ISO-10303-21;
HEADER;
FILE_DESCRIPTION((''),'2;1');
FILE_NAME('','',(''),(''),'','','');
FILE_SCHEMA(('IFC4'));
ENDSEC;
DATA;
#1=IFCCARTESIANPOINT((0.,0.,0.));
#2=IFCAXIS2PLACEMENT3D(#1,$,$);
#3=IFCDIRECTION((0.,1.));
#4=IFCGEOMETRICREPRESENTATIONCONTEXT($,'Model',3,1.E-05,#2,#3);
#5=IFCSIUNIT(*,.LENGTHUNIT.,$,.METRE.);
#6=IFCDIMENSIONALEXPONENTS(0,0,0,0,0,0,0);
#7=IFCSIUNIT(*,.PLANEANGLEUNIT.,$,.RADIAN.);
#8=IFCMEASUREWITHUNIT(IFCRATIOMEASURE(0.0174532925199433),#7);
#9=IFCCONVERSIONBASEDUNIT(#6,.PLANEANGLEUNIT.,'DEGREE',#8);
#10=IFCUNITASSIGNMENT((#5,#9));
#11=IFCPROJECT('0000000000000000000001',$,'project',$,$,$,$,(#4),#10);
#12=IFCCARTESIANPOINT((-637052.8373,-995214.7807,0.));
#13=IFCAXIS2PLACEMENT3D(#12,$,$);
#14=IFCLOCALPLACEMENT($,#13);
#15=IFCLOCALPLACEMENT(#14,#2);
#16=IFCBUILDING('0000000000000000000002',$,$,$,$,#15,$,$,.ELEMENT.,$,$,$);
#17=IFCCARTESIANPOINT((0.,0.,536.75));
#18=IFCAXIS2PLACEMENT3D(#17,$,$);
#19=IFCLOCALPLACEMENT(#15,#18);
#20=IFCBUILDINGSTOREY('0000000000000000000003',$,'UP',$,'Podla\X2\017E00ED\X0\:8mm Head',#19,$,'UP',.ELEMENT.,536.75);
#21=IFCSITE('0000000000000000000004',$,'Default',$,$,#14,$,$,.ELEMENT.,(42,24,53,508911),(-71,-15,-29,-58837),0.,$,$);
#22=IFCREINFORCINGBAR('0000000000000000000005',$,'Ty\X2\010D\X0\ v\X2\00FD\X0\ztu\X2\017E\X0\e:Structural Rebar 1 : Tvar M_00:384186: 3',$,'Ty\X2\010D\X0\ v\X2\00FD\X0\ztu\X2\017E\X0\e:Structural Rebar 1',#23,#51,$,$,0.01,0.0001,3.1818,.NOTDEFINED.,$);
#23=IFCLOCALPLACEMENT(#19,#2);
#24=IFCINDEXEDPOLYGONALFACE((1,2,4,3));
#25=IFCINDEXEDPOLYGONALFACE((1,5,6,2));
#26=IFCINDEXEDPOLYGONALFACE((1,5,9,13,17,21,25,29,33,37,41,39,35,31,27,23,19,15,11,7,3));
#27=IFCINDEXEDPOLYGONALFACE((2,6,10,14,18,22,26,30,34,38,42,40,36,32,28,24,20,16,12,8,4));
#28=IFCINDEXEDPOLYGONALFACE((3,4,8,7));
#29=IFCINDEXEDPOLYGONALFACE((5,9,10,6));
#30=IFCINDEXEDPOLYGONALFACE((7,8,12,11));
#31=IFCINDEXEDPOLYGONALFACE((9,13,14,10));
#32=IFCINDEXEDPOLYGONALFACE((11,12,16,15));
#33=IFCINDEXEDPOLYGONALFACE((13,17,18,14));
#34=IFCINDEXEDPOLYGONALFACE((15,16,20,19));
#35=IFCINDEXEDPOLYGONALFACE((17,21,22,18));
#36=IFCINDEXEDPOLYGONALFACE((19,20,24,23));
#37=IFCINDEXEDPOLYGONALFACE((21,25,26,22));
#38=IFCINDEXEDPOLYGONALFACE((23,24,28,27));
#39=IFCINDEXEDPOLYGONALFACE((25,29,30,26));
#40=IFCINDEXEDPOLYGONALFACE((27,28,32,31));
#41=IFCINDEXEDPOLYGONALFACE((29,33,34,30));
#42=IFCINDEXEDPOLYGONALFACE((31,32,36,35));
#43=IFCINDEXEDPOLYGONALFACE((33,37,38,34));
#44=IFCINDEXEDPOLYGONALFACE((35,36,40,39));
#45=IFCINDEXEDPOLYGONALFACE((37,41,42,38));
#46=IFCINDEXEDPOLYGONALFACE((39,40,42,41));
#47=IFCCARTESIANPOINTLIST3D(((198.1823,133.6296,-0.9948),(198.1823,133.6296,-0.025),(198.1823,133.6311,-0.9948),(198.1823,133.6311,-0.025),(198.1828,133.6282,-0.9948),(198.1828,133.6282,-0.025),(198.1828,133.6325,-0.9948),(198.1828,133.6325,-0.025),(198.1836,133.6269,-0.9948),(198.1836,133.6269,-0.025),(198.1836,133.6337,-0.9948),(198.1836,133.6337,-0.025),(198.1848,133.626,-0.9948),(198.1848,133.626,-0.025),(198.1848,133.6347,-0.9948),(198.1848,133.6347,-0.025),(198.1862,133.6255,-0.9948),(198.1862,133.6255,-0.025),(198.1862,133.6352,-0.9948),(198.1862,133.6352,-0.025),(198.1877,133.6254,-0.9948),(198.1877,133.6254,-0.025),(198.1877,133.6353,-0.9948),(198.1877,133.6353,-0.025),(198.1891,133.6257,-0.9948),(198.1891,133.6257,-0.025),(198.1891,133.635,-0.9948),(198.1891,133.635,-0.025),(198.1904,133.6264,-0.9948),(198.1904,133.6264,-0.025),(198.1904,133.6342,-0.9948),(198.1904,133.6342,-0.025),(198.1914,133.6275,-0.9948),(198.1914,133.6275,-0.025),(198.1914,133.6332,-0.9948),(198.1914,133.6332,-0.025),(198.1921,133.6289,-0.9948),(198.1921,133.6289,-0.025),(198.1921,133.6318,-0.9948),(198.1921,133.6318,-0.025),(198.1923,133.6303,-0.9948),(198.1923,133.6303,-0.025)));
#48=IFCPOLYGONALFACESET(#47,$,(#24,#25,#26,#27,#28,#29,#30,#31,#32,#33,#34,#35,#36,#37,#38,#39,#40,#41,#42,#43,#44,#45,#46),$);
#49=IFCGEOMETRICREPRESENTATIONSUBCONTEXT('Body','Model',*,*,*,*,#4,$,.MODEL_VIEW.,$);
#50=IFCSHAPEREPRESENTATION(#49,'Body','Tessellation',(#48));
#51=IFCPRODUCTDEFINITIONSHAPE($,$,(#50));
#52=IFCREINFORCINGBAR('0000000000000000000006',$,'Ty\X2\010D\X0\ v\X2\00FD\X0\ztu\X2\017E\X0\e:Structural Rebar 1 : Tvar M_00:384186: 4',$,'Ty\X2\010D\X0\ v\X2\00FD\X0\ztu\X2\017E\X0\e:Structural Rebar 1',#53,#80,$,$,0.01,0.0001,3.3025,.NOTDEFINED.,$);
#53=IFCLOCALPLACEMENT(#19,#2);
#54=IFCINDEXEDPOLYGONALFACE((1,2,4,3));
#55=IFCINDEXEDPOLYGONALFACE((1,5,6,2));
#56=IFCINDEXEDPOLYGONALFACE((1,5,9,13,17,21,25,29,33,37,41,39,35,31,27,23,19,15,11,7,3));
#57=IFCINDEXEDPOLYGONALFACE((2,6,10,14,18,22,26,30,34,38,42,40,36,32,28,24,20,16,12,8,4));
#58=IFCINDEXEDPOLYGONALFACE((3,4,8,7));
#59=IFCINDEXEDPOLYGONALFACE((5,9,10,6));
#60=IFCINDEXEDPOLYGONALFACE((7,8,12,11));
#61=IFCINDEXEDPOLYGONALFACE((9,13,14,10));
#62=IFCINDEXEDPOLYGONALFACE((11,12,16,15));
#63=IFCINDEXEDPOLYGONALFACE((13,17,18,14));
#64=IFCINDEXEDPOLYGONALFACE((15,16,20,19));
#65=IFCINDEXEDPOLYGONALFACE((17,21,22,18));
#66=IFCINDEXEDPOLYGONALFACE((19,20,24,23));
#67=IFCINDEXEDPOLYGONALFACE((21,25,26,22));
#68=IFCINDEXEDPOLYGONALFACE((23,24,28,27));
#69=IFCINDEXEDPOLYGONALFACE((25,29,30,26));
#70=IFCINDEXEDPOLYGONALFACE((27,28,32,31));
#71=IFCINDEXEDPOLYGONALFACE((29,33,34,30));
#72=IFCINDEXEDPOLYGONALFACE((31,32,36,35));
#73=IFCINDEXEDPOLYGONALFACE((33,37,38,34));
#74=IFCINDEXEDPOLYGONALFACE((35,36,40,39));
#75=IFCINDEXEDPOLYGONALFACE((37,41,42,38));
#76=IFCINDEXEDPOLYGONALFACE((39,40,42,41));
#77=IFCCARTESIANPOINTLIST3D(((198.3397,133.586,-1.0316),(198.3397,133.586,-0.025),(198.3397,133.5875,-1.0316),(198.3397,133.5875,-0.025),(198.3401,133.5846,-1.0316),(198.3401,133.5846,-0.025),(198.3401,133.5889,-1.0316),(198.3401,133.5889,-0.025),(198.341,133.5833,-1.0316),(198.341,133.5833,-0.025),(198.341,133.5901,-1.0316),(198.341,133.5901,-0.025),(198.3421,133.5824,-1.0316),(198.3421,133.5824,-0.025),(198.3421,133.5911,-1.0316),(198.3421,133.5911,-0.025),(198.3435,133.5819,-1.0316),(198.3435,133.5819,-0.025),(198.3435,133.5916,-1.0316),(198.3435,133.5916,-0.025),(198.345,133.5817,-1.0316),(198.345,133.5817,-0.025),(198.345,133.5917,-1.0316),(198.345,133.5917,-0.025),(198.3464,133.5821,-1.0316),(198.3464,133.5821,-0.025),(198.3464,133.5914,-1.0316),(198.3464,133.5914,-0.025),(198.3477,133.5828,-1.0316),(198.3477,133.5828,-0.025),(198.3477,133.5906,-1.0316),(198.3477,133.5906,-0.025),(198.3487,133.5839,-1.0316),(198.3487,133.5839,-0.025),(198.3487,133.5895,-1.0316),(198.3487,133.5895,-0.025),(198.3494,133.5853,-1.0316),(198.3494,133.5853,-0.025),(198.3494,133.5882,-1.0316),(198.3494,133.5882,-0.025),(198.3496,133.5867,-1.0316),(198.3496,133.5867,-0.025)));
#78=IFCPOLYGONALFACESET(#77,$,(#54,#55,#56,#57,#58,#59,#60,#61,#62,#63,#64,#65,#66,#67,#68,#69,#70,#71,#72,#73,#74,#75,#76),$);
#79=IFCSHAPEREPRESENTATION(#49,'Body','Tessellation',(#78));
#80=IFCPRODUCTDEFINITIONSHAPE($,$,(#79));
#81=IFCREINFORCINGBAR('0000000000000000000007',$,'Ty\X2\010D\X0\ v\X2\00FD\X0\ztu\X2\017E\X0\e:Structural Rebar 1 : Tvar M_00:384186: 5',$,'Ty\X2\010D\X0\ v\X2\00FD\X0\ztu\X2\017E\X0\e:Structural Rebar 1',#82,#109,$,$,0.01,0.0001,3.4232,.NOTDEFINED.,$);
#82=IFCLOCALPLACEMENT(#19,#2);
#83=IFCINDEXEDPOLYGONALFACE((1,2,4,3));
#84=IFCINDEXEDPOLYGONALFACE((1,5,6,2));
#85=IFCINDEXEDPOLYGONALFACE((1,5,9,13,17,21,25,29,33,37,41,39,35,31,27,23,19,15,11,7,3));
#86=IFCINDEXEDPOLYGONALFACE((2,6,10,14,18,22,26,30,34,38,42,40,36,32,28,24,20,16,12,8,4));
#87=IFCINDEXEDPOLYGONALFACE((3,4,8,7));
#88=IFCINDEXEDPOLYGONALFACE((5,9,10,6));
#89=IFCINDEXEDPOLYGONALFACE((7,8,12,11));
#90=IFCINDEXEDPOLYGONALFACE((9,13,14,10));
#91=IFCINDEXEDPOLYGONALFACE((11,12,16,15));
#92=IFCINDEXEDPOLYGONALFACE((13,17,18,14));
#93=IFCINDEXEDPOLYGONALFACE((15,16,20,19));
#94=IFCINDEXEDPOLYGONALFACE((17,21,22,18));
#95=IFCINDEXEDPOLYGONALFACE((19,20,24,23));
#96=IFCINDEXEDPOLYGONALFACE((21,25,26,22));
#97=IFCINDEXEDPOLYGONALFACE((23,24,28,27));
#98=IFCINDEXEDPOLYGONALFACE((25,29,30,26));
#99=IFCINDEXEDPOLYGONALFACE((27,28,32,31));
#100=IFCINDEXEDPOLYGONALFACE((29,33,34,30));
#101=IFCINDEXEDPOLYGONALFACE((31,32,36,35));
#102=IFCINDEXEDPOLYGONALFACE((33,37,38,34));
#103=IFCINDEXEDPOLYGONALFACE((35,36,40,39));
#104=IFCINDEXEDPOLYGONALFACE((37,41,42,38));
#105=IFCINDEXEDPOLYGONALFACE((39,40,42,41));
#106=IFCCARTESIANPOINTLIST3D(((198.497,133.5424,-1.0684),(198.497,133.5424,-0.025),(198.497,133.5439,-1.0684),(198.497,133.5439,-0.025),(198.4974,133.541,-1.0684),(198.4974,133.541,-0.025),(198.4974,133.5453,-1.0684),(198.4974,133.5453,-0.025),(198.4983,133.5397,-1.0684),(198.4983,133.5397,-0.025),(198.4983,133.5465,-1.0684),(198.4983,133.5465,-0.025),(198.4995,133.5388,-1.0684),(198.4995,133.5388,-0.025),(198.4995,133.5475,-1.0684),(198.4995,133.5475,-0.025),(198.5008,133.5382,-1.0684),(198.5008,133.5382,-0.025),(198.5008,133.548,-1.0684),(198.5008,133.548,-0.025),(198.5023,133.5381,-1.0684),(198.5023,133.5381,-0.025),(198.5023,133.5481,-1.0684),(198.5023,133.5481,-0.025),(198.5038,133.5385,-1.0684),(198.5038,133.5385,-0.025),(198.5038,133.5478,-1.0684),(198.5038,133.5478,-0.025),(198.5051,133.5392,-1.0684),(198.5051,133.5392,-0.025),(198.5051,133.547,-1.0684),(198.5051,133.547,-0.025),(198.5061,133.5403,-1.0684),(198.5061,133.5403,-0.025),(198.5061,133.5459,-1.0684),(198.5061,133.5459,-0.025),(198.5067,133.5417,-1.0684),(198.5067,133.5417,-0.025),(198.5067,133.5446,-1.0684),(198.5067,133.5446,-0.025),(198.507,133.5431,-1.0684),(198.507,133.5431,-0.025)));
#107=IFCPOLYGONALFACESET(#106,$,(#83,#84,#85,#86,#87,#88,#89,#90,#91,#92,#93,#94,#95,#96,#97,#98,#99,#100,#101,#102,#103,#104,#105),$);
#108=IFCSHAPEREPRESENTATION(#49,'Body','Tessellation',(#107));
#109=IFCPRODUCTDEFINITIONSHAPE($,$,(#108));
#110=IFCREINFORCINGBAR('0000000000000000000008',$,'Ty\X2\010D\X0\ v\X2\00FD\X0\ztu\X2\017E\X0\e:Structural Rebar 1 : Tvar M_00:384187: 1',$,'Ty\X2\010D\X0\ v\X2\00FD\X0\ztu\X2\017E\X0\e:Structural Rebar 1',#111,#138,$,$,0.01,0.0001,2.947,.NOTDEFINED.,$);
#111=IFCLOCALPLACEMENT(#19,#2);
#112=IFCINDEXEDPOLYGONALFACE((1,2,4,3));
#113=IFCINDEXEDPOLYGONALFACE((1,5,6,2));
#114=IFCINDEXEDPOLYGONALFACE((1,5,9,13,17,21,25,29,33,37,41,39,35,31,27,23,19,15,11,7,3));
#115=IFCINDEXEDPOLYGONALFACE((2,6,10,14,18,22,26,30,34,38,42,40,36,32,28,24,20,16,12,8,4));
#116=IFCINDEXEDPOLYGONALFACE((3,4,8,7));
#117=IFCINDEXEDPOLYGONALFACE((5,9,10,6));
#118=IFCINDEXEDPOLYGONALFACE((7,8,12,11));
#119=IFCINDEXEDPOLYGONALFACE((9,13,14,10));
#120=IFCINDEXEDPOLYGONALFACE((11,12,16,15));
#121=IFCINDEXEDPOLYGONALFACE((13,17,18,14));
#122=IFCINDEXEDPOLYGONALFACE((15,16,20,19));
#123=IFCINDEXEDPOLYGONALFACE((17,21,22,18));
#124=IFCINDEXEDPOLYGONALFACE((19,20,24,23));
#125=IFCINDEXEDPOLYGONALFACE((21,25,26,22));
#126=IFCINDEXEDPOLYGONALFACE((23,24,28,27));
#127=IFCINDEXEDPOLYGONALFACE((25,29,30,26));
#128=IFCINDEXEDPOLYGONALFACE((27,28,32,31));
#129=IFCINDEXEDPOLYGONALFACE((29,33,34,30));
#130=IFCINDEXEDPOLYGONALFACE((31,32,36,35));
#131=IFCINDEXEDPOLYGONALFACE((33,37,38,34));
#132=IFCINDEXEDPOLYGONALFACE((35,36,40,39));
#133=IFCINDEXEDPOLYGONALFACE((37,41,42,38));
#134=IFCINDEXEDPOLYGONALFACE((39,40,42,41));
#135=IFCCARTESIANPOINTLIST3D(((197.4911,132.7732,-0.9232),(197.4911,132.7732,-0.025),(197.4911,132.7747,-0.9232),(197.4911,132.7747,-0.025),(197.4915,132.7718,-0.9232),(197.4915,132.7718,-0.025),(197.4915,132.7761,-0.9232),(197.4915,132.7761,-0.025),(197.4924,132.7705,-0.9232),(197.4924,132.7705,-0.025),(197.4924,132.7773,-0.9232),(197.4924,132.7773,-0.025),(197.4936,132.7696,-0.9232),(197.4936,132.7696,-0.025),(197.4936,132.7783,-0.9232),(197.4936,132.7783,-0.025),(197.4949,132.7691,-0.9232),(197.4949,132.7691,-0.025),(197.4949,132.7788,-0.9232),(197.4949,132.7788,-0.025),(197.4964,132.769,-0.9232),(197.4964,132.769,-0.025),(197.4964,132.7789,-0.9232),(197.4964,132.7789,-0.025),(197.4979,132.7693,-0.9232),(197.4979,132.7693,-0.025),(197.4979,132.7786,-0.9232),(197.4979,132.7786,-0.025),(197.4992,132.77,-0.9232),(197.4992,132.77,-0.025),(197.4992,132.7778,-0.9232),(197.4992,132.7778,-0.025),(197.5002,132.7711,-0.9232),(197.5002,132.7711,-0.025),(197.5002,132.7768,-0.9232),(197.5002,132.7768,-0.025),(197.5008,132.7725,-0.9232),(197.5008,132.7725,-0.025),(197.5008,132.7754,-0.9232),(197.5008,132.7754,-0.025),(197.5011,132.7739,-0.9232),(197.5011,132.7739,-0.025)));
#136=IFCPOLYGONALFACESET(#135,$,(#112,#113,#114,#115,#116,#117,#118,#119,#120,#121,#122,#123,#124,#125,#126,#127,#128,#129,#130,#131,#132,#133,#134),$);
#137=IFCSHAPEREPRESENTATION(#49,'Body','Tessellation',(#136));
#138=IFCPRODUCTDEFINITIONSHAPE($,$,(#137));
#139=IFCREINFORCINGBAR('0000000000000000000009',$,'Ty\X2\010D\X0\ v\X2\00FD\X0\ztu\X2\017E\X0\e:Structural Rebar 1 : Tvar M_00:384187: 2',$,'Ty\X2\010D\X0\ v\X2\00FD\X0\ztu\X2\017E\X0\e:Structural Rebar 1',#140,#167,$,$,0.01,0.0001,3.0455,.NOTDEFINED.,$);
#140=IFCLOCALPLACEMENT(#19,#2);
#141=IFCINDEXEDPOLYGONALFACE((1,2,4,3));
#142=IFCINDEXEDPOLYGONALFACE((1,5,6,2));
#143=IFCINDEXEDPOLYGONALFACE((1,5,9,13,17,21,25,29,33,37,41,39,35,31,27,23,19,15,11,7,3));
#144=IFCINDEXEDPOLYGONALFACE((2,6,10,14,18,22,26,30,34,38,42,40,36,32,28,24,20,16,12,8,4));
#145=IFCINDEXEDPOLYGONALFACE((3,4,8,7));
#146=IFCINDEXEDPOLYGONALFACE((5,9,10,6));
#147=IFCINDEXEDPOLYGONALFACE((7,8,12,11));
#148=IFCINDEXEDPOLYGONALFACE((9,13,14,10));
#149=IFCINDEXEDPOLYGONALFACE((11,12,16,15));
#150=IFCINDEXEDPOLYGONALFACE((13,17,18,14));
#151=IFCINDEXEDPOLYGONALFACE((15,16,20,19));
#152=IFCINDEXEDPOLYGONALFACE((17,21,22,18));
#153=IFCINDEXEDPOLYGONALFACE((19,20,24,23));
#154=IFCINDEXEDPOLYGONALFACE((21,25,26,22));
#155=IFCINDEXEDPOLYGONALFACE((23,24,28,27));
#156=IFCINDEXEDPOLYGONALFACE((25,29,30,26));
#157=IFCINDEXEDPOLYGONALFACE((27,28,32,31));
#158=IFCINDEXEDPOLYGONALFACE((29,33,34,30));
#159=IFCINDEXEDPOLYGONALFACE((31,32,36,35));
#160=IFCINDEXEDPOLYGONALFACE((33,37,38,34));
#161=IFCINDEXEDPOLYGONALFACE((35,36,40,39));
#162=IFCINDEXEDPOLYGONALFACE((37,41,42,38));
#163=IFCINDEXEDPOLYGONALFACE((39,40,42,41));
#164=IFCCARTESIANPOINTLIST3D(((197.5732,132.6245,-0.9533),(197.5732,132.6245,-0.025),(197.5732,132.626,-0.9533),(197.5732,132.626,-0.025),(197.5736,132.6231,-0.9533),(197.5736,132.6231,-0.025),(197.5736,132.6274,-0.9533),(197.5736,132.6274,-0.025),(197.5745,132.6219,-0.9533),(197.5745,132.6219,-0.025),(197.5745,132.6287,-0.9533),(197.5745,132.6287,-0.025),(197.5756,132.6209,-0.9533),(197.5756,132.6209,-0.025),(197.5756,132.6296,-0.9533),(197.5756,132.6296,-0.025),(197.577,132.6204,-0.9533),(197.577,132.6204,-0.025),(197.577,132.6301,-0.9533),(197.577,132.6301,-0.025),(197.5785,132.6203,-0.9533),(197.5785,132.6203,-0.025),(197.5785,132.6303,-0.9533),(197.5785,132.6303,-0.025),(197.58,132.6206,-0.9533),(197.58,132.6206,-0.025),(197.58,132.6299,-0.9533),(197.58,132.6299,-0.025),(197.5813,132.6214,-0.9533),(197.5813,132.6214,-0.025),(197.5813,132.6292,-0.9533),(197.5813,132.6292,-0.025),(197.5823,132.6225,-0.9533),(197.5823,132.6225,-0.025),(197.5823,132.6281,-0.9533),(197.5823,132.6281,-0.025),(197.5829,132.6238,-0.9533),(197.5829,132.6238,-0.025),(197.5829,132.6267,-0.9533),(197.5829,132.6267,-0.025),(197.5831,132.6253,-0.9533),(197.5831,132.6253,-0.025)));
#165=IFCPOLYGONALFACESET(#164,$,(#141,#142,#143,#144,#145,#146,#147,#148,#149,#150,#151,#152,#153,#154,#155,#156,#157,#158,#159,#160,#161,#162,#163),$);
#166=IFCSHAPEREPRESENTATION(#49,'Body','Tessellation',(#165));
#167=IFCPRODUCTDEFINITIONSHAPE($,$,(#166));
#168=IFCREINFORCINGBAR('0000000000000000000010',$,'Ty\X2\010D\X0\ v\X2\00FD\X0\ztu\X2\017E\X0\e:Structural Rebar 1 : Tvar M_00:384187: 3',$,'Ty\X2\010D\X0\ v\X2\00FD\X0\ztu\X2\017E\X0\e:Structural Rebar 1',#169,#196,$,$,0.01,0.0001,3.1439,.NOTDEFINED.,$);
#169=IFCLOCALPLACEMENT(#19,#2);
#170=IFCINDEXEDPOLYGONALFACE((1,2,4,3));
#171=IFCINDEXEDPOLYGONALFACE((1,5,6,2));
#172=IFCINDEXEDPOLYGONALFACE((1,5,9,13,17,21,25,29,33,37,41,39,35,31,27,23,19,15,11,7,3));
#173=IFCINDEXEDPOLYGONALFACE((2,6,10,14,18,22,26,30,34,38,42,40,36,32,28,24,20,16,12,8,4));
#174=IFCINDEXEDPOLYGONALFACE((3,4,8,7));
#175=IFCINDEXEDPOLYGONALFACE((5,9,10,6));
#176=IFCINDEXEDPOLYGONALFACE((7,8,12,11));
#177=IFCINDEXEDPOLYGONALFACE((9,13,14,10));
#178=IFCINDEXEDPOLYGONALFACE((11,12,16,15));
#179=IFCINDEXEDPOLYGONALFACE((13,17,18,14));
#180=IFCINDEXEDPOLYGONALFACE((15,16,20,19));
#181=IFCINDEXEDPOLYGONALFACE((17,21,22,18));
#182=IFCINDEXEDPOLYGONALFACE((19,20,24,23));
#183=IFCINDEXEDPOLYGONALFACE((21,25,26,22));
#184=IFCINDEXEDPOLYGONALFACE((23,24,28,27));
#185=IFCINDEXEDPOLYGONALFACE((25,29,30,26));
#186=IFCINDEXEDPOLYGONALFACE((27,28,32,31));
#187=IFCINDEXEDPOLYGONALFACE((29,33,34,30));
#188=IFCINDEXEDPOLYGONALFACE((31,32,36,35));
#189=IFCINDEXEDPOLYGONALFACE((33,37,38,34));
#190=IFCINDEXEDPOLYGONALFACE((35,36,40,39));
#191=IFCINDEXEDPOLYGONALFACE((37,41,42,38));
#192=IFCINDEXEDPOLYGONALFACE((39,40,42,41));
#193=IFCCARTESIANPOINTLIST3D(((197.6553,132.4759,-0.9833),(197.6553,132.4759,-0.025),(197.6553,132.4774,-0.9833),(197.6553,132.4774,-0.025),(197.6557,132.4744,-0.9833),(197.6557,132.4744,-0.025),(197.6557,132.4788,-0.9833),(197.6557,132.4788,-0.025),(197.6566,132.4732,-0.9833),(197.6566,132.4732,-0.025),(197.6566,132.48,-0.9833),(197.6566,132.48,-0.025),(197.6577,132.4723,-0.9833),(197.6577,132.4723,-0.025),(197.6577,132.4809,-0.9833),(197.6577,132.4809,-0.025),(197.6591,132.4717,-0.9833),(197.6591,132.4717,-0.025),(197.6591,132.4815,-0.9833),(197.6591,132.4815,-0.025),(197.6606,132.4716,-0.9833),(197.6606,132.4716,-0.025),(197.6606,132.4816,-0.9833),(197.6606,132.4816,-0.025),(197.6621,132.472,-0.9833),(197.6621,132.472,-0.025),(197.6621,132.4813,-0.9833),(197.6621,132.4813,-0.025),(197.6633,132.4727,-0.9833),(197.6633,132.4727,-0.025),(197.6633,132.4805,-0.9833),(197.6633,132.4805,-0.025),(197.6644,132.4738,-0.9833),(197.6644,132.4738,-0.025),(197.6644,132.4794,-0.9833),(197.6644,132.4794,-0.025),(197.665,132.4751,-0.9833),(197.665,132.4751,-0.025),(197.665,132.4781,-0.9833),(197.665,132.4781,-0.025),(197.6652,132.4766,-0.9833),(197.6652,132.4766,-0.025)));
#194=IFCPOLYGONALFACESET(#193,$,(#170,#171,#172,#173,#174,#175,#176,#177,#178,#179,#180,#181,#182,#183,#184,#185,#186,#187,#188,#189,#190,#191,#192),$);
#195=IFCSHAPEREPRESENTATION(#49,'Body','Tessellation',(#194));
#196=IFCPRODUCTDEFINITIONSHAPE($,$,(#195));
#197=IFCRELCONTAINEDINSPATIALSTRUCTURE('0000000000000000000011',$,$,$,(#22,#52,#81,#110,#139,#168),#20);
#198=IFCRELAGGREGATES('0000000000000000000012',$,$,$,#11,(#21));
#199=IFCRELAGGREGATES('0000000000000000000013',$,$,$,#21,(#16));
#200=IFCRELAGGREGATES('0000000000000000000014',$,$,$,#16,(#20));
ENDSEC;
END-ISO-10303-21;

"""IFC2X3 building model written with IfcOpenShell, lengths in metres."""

from ifc_helpers import new_model, entity, si_unit, converted_unit, direction, frame, origin, place, context, subcontext, project, spatial, element, save


model = new_model("IFC2X3")

# Units and contexts
model_context = context("Model", 3, precision=1e-05, world=origin(), true_north=direction((0.0, 1.0)))
body_context = subcontext(model_context, "Body", "Model", "MODEL_VIEW")
ifc_project = project(units=[si_unit("LENGTHUNIT", "METRE"), converted_unit("PLANEANGLEUNIT", "DEGREE", entity("IfcRatioMeasure", 0.0174532925199433), si_unit("PLANEANGLEUNIT", "RADIAN"), dimensions=[0, 0, 0, 0, 0, 0, 0])], contexts=[model_context])

# Site, building, storey
site_placement = place(None, frame((-637052.8373, -995214.7807, 0.0)))
site = spatial("IfcSite", under=ifc_project, at=site_placement, Name="Default", CompositionType="ELEMENT", RefLatitude=(42, 24, 53, 508911), RefLongitude=(-71, -15, -29, -58837), RefElevation=0.0)
building_placement = place(site_placement, origin())
building = spatial("IfcBuilding", under=site, at=building_placement, CompositionType="ELEMENT")
storey_placement = place(building_placement, frame((0.0, 0.0, 536.75)))
storey = spatial("IfcBuildingStorey", under=building, at=storey_placement, Name="UP", ObjectType="Podlaží:8mm Head", LongName="UP", CompositionType="ELEMENT", Elevation=536.75)

# Reinforcing bars
reinforcing_bar_1_placement = place(storey_placement, origin())
element("IfcReinforcingBar", 1, at=reinforcing_bar_1_placement, inside=storey, Name="Tyč výztuže:Structural Rebar 1 : Tvar M_00:384186: 3", ObjectType="Tyč výztuže:Structural Rebar 1", BarLength=3.1818, BarRole="NOTDEFINED", CrossSectionArea=0.0001, NominalDiameter=0.01, context=body_context, shape_type="AdvancedSweptSolid", body=[
    entity("IfcSweptDiskSolid", entity("IfcCompositeCurve", [entity("IfcCompositeCurveSegment", "CONTINUOUS", True, entity("IfcPolyline", [entity("IfcCartesianPoint", [-198.1873, -133.6303, 0.025]), entity("IfcCartesianPoint", [-198.1873, -133.6303, 0.9948])]))], False), 0.005, None, 0.0, 1.0),
])
reinforcing_bar_2_placement = place(storey_placement, origin())
element("IfcReinforcingBar", 2, at=reinforcing_bar_2_placement, inside=storey, Name="Tyč výztuže:Structural Rebar 1 : Tvar M_00:384186: 4", ObjectType="Tyč výztuže:Structural Rebar 1", BarLength=3.3025, BarRole="NOTDEFINED", CrossSectionArea=0.0001, NominalDiameter=0.01, context=body_context, shape_type="AdvancedSweptSolid", body=[
    entity("IfcSweptDiskSolid", entity("IfcCompositeCurve", [entity("IfcCompositeCurveSegment", "CONTINUOUS", True, entity("IfcPolyline", [entity("IfcCartesianPoint", [-198.3446, -133.5867, 0.025]), entity("IfcCartesianPoint", [-198.3446, -133.5867, 1.0316])]))], False), 0.005, None, 0.0, 1.0),
])
reinforcing_bar_3_placement = place(storey_placement, origin())
element("IfcReinforcingBar", 3, at=reinforcing_bar_3_placement, inside=storey, Name="Tyč výztuže:Structural Rebar 1 : Tvar M_00:384186: 5", ObjectType="Tyč výztuže:Structural Rebar 1", BarLength=3.4232, BarRole="NOTDEFINED", CrossSectionArea=0.0001, NominalDiameter=0.01, context=body_context, shape_type="AdvancedSweptSolid", body=[
    entity("IfcSweptDiskSolid", entity("IfcCompositeCurve", [entity("IfcCompositeCurveSegment", "CONTINUOUS", True, entity("IfcPolyline", [entity("IfcCartesianPoint", [-198.502, -133.5431, 0.025]), entity("IfcCartesianPoint", [-198.502, -133.5431, 1.0684])]))], False), 0.005, None, 0.0, 1.0),
])
reinforcing_bar_4_placement = place(storey_placement, origin())
element("IfcReinforcingBar", 4, at=reinforcing_bar_4_placement, inside=storey, Name="Tyč výztuže:Structural Rebar 1 : Tvar M_00:384187: 1", ObjectType="Tyč výztuže:Structural Rebar 1", BarLength=2.947, BarRole="NOTDEFINED", CrossSectionArea=0.0001, NominalDiameter=0.01, context=body_context, shape_type="AdvancedSweptSolid", body=[
    entity("IfcSweptDiskSolid", entity("IfcCompositeCurve", [entity("IfcCompositeCurveSegment", "CONTINUOUS", True, entity("IfcPolyline", [entity("IfcCartesianPoint", [-197.4961, -132.7739, 0.025]), entity("IfcCartesianPoint", [-197.4961, -132.7739, 0.9232])]))], False), 0.005, None, 0.0, 1.0),
])
reinforcing_bar_5_placement = place(storey_placement, origin())
element("IfcReinforcingBar", 5, at=reinforcing_bar_5_placement, inside=storey, Name="Tyč výztuže:Structural Rebar 1 : Tvar M_00:384187: 2", ObjectType="Tyč výztuže:Structural Rebar 1", BarLength=3.0455, BarRole="NOTDEFINED", CrossSectionArea=0.0001, NominalDiameter=0.01, context=body_context, shape_type="AdvancedSweptSolid", body=[
    entity("IfcSweptDiskSolid", entity("IfcCompositeCurve", [entity("IfcCompositeCurveSegment", "CONTINUOUS", True, entity("IfcPolyline", [entity("IfcCartesianPoint", [-197.5781, -132.6253, 0.025]), entity("IfcCartesianPoint", [-197.5781, -132.6253, 0.9533])]))], False), 0.005, None, 0.0, 1.0),
])
reinforcing_bar_6_placement = place(storey_placement, origin())
element("IfcReinforcingBar", 6, at=reinforcing_bar_6_placement, inside=storey, Name="Tyč výztuže:Structural Rebar 1 : Tvar M_00:384187: 3", ObjectType="Tyč výztuže:Structural Rebar 1", BarLength=3.1439, BarRole="NOTDEFINED", CrossSectionArea=0.0001, NominalDiameter=0.01, context=body_context, shape_type="AdvancedSweptSolid", body=[
    entity("IfcSweptDiskSolid", entity("IfcCompositeCurve", [entity("IfcCompositeCurveSegment", "CONTINUOUS", True, entity("IfcPolyline", [entity("IfcCartesianPoint", [-197.6602, -132.4766, 0.025]), entity("IfcCartesianPoint", [-197.6602, -132.4766, 0.9833])]))], False), 0.005, None, 0.0, 1.0),
])

save(model, "model.ifc")
